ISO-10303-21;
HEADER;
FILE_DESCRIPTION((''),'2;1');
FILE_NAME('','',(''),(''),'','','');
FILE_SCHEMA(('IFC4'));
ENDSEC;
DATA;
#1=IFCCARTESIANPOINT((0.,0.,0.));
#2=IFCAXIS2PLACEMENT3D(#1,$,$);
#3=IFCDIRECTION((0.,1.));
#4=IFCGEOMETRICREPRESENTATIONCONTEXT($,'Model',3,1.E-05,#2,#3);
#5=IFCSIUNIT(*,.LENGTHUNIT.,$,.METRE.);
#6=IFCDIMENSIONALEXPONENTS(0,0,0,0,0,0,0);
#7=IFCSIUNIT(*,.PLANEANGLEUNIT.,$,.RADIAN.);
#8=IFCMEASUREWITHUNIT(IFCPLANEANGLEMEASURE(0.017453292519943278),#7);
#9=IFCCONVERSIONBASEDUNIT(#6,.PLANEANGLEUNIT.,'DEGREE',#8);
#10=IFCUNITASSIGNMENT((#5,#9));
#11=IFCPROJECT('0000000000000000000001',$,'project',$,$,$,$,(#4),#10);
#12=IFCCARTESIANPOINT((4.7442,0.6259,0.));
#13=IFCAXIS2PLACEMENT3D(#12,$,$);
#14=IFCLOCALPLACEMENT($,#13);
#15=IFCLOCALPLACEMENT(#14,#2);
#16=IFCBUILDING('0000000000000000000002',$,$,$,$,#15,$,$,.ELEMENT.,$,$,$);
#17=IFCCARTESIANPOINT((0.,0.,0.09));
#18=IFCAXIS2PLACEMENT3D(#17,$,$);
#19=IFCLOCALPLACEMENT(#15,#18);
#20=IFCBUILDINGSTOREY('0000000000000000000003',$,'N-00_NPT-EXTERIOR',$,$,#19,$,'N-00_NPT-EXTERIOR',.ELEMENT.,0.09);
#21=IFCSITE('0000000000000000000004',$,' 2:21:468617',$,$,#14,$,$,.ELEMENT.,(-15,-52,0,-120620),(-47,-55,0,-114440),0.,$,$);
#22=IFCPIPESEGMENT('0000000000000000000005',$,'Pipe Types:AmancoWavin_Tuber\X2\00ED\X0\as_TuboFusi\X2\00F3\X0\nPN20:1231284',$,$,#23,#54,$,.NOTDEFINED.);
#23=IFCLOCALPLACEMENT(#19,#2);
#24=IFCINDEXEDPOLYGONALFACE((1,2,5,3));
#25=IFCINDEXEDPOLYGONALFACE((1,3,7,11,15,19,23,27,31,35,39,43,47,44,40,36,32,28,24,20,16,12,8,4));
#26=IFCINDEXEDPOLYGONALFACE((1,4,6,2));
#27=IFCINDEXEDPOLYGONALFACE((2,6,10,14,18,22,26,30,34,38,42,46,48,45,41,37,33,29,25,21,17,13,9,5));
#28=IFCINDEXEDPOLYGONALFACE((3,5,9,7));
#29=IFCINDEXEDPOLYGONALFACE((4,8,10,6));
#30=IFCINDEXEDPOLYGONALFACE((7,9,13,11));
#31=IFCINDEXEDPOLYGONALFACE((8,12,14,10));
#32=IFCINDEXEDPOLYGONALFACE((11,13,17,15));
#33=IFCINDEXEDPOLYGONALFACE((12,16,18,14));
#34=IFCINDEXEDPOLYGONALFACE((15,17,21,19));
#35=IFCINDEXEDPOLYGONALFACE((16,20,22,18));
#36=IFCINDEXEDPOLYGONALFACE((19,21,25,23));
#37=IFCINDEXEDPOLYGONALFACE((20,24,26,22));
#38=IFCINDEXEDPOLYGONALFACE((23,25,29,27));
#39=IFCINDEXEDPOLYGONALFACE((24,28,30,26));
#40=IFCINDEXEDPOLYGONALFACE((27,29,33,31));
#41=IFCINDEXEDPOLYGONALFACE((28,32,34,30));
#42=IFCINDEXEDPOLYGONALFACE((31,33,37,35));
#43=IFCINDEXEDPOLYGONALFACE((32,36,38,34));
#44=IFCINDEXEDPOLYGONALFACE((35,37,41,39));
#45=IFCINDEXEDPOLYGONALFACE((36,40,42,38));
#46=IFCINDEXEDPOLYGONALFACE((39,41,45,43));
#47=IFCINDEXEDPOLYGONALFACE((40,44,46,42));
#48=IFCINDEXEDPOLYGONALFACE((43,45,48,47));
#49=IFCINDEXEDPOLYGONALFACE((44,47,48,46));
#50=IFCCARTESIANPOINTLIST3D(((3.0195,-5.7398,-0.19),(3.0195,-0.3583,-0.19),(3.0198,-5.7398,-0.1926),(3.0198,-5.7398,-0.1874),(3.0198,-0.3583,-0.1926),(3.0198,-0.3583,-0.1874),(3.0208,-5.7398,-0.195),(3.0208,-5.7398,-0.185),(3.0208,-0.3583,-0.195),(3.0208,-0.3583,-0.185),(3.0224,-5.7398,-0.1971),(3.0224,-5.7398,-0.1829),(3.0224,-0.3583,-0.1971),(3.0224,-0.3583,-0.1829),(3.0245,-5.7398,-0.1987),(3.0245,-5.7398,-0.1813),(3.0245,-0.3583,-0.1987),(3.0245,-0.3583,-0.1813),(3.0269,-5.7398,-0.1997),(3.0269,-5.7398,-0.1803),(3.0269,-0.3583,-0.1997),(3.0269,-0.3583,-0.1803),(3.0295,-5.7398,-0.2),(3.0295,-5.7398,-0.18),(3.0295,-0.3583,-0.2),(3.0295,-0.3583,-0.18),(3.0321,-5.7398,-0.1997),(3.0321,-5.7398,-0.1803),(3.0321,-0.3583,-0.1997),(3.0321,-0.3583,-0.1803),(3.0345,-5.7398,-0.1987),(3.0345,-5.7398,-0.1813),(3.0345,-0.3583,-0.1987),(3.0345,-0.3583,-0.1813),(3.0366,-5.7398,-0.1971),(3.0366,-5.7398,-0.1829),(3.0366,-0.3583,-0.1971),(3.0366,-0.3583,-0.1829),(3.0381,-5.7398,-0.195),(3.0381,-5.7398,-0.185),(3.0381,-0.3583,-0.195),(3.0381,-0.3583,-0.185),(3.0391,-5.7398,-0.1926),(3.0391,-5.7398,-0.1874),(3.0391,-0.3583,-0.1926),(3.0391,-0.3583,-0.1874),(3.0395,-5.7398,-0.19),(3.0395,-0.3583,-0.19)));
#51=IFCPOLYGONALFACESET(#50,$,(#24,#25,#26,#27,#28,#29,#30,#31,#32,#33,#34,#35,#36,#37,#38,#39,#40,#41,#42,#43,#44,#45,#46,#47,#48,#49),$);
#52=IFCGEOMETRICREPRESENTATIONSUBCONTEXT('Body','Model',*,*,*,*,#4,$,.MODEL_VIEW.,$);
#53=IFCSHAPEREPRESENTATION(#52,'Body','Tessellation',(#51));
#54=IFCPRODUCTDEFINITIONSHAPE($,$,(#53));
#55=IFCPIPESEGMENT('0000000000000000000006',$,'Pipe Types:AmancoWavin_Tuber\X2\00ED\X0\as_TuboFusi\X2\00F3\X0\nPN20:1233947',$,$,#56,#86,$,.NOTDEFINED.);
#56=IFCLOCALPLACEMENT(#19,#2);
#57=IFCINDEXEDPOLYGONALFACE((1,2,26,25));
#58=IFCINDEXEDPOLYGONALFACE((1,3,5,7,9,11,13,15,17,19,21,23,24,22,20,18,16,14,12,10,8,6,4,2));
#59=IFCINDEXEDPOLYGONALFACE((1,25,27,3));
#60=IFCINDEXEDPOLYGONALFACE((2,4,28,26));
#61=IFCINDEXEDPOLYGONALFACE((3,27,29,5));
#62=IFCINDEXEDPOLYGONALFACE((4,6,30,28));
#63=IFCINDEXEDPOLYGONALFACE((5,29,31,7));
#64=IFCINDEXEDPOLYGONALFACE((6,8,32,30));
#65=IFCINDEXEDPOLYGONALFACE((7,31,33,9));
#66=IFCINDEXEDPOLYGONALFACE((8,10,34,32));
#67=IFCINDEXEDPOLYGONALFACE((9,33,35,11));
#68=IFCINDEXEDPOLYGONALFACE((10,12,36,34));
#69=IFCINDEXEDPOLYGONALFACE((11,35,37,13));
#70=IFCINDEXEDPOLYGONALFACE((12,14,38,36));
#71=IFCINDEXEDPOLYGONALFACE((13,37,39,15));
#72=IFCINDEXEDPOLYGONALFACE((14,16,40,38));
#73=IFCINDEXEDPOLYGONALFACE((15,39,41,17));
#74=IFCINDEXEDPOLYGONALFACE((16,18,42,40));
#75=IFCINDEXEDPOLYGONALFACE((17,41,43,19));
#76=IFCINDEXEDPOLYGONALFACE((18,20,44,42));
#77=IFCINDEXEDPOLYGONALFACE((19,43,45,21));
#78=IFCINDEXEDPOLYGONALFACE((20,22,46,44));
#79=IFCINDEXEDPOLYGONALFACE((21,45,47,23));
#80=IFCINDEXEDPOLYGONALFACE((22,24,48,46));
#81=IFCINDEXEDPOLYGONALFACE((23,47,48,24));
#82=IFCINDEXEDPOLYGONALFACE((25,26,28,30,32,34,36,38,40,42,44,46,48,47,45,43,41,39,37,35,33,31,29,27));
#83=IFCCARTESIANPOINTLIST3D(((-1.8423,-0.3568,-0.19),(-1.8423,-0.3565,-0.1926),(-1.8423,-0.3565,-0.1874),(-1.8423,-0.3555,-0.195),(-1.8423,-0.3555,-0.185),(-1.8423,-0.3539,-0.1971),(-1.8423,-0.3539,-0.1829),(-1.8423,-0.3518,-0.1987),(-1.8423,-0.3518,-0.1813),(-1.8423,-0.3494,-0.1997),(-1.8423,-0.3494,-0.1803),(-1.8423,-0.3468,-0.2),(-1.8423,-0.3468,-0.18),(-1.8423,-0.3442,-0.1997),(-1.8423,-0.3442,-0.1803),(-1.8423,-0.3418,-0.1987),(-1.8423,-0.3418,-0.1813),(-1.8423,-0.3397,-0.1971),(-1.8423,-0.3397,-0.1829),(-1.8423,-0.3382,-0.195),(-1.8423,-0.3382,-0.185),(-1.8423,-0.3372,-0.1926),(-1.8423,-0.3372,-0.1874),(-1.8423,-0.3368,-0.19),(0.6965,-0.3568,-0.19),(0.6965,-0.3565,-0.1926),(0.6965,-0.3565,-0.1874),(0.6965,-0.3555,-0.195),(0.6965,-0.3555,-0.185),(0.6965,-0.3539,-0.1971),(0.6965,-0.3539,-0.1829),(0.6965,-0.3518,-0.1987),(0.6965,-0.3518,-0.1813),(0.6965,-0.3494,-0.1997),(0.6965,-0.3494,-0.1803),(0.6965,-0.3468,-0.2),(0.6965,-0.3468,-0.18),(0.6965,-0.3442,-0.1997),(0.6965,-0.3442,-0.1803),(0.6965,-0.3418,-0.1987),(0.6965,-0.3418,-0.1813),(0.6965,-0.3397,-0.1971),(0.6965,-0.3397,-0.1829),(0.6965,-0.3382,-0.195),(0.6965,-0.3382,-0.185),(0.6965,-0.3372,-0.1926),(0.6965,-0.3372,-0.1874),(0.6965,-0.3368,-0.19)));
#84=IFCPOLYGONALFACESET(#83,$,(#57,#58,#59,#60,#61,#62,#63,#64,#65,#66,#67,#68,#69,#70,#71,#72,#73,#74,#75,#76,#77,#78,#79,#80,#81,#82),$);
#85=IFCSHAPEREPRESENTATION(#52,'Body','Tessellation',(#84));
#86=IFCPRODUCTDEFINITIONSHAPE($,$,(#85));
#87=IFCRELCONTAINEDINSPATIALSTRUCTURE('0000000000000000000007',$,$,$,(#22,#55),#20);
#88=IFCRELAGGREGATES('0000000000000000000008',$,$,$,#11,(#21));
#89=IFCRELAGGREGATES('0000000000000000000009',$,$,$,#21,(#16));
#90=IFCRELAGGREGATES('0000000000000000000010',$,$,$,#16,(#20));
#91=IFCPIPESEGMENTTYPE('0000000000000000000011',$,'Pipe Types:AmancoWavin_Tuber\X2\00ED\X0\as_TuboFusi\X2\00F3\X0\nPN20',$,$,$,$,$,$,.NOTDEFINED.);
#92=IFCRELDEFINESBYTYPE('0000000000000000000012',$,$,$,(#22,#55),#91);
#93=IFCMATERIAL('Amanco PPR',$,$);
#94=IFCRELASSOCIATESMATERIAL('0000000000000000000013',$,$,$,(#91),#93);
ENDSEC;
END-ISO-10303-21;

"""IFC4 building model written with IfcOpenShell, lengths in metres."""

from ifc_helpers import new_model, entity, si_unit, converted_unit, direction, frame, origin, place, context, subcontext, project, spatial, arc, indexed_curve, outline, extrude, material, type_object, element, save


model = new_model("IFC4")

# Units and contexts
model_context = context("Model", 3, precision=1e-05, world=origin(), true_north=direction((0.0, 1.0)))
body_context = subcontext(model_context, "Body", "Model", "MODEL_VIEW")
ifc_project = project(units=[si_unit("LENGTHUNIT", "METRE"), converted_unit("PLANEANGLEUNIT", "DEGREE", entity("IfcPlaneAngleMeasure", 0.017453292519943278), si_unit("PLANEANGLEUNIT", "RADIAN"), dimensions=[0, 0, 0, 0, 0, 0, 0])], contexts=[model_context])

# Site, building, storey
site_placement = place(None, frame((4.7442, 0.6259, 0.0)))
site = spatial("IfcSite", under=ifc_project, at=site_placement, Name=" 2:21:468617", CompositionType="ELEMENT", RefLatitude=(-15, -52, 0, -120620), RefLongitude=(-47, -55, 0, -114440), RefElevation=0.0)
building_placement = place(site_placement, origin())
building = spatial("IfcBuilding", under=site, at=building_placement, CompositionType="ELEMENT")
storey_placement = place(building_placement, frame((0.0, 0.0, 0.09)))
storey = spatial("IfcBuildingStorey", under=building, at=storey_placement, Name="N-00_NPT-EXTERIOR", LongName="N-00_NPT-EXTERIOR", CompositionType="ELEMENT", Elevation=0.09)

# Pipe segments
ifc_material_1 = material(Name="Amanco PPR")
pipe_segment_type_1 = type_object("IfcPipeSegmentType", Name="Pipe Types:AmancoWavin_Tuberías_TuboFusiónPN20", PredefinedType="NOTDEFINED", material=ifc_material_1)
pipe_segment_1_placement = place(storey_placement, origin())
element("IfcPipeSegment", 1, at=pipe_segment_1_placement, inside=storey, type_object=pipe_segment_type_1, Name="Pipe Types:AmancoWavin_Tuberías_TuboFusiónPN20:1231284", PredefinedType="NOTDEFINED", context=body_context, shape_type="SweptSolid", body=[
    extrude(outline(indexed_curve([(0.01, 0.0), (0.0071, 0.0071), (0.0, 0.01), (-0.0071, 0.0071), (-0.01, 0.0), (-0.0071, -0.0071), (0.0, -0.01), (0.0071, -0.0071)], segments=[arc(1, 2, 3), arc(3, 4, 5), arc(5, 6, 7), arc(7, 8, 1)], self_intersect=False)), frame((3.0295, -5.7398, -0.19), z_axis=(0.0, 1.0, 0.0), x_axis=(-1.0, 0.0, 0.0)), (0.0, 0.0, 1.0), 5.3815),
])
pipe_segment_2_placement = place(storey_placement, origin())
element("IfcPipeSegment", 2, at=pipe_segment_2_placement, inside=storey, type_object=pipe_segment_type_1, Name="Pipe Types:AmancoWavin_Tuberías_TuboFusiónPN20:1233947", PredefinedType="NOTDEFINED", context=body_context, shape_type="SweptSolid", body=[
    extrude(outline(indexed_curve([(0.01, 0.0), (0.0071, 0.0071), (0.0, 0.01), (-0.0071, 0.0071), (-0.01, 0.0), (-0.0071, -0.0071), (0.0, -0.01), (0.0071, -0.0071)], segments=[arc(1, 2, 3), arc(3, 4, 5), arc(5, 6, 7), arc(7, 8, 1)], self_intersect=False)), frame((-1.8423, -0.3468, -0.19), z_axis=(1.0, 0.0, 0.0), x_axis=(0.0, -1.0, 0.0)), (0.0, 0.0, 1.0), 2.5387),
])

save(model, "model.ifc")
